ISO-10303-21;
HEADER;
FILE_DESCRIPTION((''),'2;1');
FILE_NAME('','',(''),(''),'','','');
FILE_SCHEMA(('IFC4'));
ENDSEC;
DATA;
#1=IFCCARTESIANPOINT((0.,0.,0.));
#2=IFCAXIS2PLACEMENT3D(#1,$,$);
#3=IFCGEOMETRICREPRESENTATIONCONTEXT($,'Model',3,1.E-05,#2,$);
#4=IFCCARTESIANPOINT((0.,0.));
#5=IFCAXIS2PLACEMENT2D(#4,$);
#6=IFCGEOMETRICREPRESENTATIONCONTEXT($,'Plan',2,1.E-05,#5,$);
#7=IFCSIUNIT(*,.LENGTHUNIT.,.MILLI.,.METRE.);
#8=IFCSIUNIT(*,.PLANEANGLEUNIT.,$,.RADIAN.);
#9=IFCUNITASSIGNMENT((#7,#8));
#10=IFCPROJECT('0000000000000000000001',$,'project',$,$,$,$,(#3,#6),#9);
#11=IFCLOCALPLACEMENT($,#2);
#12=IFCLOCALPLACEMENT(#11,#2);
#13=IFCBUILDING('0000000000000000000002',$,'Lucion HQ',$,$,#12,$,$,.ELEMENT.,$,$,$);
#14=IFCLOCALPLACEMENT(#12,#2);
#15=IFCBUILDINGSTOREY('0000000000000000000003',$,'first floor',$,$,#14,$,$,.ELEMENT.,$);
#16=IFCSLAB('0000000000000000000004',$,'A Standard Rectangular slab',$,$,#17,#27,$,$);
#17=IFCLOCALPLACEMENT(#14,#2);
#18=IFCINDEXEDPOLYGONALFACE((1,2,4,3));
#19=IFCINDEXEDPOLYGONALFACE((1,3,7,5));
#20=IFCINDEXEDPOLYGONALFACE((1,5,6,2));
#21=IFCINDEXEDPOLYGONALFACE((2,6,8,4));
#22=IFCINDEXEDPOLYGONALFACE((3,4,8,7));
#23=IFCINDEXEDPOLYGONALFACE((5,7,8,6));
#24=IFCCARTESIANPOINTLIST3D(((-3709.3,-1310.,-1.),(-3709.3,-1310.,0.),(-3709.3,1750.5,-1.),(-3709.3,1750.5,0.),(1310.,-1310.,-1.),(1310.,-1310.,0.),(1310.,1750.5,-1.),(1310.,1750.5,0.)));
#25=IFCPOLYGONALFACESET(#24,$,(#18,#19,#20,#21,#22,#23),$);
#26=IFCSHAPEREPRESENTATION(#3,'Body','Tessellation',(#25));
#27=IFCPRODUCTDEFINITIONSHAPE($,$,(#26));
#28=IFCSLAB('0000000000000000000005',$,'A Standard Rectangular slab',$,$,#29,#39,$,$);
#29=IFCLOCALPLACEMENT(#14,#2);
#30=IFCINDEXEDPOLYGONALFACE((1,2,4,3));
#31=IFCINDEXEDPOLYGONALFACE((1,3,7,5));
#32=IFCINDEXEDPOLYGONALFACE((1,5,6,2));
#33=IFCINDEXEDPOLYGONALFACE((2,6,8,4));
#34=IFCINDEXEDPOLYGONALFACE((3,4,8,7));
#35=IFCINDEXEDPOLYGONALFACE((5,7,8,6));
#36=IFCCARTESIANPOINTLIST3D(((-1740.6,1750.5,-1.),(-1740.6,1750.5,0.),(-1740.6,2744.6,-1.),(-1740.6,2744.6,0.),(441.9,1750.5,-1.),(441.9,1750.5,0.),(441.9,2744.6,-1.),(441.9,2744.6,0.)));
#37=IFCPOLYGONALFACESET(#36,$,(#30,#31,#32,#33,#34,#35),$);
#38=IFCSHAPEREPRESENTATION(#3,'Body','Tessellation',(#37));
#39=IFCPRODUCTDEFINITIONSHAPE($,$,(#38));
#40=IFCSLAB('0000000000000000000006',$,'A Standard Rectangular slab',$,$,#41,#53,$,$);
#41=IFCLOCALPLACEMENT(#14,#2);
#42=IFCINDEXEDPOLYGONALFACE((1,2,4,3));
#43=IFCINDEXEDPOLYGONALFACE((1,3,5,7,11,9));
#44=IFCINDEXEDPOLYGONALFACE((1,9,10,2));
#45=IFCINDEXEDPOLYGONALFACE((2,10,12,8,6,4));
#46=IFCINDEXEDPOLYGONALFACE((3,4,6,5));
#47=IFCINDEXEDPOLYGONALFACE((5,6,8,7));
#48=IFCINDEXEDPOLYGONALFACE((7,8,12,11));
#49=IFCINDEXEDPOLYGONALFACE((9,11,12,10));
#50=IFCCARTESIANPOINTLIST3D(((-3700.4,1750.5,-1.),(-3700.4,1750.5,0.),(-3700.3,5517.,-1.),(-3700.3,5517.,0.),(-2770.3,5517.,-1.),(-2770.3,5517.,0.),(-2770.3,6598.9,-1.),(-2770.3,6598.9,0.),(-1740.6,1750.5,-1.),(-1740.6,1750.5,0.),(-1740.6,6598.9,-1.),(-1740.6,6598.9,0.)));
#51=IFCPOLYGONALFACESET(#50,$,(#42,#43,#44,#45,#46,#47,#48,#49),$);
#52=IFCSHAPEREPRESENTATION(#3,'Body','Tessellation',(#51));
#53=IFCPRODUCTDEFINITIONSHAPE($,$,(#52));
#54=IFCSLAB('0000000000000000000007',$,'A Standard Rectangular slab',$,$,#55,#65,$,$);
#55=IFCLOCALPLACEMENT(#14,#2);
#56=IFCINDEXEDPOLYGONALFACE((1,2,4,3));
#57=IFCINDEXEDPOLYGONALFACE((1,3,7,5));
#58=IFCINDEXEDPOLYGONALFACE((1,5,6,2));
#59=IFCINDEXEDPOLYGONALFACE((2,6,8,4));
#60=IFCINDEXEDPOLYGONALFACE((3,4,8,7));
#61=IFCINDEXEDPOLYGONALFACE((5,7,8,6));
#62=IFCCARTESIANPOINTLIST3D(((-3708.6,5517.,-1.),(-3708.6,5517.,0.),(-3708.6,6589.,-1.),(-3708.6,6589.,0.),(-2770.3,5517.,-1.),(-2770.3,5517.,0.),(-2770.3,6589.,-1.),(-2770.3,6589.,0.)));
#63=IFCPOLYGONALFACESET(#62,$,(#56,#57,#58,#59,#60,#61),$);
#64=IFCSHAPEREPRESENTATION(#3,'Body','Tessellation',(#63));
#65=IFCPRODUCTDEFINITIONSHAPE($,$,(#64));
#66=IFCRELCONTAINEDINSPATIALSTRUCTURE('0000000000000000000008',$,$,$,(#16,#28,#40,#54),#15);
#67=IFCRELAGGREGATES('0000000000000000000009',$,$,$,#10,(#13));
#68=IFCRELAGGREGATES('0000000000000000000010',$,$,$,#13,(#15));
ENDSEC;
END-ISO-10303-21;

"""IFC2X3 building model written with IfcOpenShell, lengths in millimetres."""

from ifc_helpers import new_model, si_unit, frame, origin, origin_2d, place, context, project, spatial, polyline, outline, extrude, element, save


model = new_model("IFC2X3")

# Units and contexts
model_context = context("Model", 3, precision=1e-05, world=origin())
plan_context = context("Plan", 2, precision=1e-05, world=origin_2d())
ifc_project = project(units=[si_unit("LENGTHUNIT", "METRE", prefix="MILLI"), si_unit("PLANEANGLEUNIT", "RADIAN")], contexts=[model_context, plan_context])

# Building, storey
placement_1 = place(None, origin())
building_placement = place(placement_1, origin())
building = spatial("IfcBuilding", under=ifc_project, at=building_placement, Name="Lucion HQ", CompositionType="ELEMENT")
storey_placement = place(building_placement, origin())
storey = spatial("IfcBuildingStorey", under=building, at=storey_placement, Name="first floor", CompositionType="ELEMENT")

# Slabs
placement_2 = place(None, frame((-1199.6, 220.3, 0.0)))
slab_1_placement = place(placement_2, origin())
element("IfcSlab", 1, at=slab_1_placement, inside=storey, Name="A Standard Rectangular slab", context=model_context, shape_type="SweptSolid", body=[
    extrude(outline(polyline([(2509.6, -1530.2, 0.0), (-2509.6, -1530.2, 0.0), (-2509.6, 1530.2, 0.0), (2509.6, 1530.2, 0.0), (2509.6, -1530.2, 0.0)]), kind="CURVE"), origin(), (0.0, 0.0, -1.0), 1.0),
])
placement_3 = place(None, frame((-649.3, 2247.6, 0.0)))
slab_2_placement = place(placement_3, origin())
element("IfcSlab", 2, at=slab_2_placement, inside=storey, Name="A Standard Rectangular slab", context=model_context, shape_type="SweptSolid", body=[
    extrude(outline(polyline([(1091.3, -497.1, 0.0), (-1091.3, -497.1, 0.0), (-1091.3, 497.1, 0.0), (1091.3, 497.1, 0.0), (1091.3, -497.1, 0.0)]), kind="CURVE"), origin(), (0.0, 0.0, -1.0), 1.0),
])
placement_4 = place(None, frame((-2720.5, 4174.7, 0.0)))
slab_3_placement = place(placement_4, origin())
element("IfcSlab", 3, at=slab_3_placement, inside=storey, Name="A Standard Rectangular slab", context=model_context, shape_type="SweptSolid", body=[
    extrude(outline(polyline([(979.9, -2424.2, 0.0), (-979.9, -2424.2, 0.0), (-979.9, 1342.3, 0.0), (-49.9, 1342.3, 0.0), (-49.9, 2424.2, 0.0), (979.9, 2424.2, 0.0), (979.9, -2424.2, 0.0)]), kind="CURVE"), origin(), (0.0, 0.0, -1.0), 1.0),
])
placement_5 = place(None, frame((-3239.5, 6053.0, 0.0)))
slab_4_placement = place(placement_5, origin())
element("IfcSlab", 4, at=slab_4_placement, inside=storey, Name="A Standard Rectangular slab", context=model_context, shape_type="SweptSolid", body=[
    extrude(outline(polyline([(469.2, -536.0, 0.0), (-469.2, -536.0, 0.0), (-469.2, 536.0, 0.0), (469.2, 536.0, 0.0), (469.2, -536.0, 0.0)]), kind="CURVE"), origin(), (0.0, 0.0, -1.0), 1.0),
])

save(model, "model.ifc")
